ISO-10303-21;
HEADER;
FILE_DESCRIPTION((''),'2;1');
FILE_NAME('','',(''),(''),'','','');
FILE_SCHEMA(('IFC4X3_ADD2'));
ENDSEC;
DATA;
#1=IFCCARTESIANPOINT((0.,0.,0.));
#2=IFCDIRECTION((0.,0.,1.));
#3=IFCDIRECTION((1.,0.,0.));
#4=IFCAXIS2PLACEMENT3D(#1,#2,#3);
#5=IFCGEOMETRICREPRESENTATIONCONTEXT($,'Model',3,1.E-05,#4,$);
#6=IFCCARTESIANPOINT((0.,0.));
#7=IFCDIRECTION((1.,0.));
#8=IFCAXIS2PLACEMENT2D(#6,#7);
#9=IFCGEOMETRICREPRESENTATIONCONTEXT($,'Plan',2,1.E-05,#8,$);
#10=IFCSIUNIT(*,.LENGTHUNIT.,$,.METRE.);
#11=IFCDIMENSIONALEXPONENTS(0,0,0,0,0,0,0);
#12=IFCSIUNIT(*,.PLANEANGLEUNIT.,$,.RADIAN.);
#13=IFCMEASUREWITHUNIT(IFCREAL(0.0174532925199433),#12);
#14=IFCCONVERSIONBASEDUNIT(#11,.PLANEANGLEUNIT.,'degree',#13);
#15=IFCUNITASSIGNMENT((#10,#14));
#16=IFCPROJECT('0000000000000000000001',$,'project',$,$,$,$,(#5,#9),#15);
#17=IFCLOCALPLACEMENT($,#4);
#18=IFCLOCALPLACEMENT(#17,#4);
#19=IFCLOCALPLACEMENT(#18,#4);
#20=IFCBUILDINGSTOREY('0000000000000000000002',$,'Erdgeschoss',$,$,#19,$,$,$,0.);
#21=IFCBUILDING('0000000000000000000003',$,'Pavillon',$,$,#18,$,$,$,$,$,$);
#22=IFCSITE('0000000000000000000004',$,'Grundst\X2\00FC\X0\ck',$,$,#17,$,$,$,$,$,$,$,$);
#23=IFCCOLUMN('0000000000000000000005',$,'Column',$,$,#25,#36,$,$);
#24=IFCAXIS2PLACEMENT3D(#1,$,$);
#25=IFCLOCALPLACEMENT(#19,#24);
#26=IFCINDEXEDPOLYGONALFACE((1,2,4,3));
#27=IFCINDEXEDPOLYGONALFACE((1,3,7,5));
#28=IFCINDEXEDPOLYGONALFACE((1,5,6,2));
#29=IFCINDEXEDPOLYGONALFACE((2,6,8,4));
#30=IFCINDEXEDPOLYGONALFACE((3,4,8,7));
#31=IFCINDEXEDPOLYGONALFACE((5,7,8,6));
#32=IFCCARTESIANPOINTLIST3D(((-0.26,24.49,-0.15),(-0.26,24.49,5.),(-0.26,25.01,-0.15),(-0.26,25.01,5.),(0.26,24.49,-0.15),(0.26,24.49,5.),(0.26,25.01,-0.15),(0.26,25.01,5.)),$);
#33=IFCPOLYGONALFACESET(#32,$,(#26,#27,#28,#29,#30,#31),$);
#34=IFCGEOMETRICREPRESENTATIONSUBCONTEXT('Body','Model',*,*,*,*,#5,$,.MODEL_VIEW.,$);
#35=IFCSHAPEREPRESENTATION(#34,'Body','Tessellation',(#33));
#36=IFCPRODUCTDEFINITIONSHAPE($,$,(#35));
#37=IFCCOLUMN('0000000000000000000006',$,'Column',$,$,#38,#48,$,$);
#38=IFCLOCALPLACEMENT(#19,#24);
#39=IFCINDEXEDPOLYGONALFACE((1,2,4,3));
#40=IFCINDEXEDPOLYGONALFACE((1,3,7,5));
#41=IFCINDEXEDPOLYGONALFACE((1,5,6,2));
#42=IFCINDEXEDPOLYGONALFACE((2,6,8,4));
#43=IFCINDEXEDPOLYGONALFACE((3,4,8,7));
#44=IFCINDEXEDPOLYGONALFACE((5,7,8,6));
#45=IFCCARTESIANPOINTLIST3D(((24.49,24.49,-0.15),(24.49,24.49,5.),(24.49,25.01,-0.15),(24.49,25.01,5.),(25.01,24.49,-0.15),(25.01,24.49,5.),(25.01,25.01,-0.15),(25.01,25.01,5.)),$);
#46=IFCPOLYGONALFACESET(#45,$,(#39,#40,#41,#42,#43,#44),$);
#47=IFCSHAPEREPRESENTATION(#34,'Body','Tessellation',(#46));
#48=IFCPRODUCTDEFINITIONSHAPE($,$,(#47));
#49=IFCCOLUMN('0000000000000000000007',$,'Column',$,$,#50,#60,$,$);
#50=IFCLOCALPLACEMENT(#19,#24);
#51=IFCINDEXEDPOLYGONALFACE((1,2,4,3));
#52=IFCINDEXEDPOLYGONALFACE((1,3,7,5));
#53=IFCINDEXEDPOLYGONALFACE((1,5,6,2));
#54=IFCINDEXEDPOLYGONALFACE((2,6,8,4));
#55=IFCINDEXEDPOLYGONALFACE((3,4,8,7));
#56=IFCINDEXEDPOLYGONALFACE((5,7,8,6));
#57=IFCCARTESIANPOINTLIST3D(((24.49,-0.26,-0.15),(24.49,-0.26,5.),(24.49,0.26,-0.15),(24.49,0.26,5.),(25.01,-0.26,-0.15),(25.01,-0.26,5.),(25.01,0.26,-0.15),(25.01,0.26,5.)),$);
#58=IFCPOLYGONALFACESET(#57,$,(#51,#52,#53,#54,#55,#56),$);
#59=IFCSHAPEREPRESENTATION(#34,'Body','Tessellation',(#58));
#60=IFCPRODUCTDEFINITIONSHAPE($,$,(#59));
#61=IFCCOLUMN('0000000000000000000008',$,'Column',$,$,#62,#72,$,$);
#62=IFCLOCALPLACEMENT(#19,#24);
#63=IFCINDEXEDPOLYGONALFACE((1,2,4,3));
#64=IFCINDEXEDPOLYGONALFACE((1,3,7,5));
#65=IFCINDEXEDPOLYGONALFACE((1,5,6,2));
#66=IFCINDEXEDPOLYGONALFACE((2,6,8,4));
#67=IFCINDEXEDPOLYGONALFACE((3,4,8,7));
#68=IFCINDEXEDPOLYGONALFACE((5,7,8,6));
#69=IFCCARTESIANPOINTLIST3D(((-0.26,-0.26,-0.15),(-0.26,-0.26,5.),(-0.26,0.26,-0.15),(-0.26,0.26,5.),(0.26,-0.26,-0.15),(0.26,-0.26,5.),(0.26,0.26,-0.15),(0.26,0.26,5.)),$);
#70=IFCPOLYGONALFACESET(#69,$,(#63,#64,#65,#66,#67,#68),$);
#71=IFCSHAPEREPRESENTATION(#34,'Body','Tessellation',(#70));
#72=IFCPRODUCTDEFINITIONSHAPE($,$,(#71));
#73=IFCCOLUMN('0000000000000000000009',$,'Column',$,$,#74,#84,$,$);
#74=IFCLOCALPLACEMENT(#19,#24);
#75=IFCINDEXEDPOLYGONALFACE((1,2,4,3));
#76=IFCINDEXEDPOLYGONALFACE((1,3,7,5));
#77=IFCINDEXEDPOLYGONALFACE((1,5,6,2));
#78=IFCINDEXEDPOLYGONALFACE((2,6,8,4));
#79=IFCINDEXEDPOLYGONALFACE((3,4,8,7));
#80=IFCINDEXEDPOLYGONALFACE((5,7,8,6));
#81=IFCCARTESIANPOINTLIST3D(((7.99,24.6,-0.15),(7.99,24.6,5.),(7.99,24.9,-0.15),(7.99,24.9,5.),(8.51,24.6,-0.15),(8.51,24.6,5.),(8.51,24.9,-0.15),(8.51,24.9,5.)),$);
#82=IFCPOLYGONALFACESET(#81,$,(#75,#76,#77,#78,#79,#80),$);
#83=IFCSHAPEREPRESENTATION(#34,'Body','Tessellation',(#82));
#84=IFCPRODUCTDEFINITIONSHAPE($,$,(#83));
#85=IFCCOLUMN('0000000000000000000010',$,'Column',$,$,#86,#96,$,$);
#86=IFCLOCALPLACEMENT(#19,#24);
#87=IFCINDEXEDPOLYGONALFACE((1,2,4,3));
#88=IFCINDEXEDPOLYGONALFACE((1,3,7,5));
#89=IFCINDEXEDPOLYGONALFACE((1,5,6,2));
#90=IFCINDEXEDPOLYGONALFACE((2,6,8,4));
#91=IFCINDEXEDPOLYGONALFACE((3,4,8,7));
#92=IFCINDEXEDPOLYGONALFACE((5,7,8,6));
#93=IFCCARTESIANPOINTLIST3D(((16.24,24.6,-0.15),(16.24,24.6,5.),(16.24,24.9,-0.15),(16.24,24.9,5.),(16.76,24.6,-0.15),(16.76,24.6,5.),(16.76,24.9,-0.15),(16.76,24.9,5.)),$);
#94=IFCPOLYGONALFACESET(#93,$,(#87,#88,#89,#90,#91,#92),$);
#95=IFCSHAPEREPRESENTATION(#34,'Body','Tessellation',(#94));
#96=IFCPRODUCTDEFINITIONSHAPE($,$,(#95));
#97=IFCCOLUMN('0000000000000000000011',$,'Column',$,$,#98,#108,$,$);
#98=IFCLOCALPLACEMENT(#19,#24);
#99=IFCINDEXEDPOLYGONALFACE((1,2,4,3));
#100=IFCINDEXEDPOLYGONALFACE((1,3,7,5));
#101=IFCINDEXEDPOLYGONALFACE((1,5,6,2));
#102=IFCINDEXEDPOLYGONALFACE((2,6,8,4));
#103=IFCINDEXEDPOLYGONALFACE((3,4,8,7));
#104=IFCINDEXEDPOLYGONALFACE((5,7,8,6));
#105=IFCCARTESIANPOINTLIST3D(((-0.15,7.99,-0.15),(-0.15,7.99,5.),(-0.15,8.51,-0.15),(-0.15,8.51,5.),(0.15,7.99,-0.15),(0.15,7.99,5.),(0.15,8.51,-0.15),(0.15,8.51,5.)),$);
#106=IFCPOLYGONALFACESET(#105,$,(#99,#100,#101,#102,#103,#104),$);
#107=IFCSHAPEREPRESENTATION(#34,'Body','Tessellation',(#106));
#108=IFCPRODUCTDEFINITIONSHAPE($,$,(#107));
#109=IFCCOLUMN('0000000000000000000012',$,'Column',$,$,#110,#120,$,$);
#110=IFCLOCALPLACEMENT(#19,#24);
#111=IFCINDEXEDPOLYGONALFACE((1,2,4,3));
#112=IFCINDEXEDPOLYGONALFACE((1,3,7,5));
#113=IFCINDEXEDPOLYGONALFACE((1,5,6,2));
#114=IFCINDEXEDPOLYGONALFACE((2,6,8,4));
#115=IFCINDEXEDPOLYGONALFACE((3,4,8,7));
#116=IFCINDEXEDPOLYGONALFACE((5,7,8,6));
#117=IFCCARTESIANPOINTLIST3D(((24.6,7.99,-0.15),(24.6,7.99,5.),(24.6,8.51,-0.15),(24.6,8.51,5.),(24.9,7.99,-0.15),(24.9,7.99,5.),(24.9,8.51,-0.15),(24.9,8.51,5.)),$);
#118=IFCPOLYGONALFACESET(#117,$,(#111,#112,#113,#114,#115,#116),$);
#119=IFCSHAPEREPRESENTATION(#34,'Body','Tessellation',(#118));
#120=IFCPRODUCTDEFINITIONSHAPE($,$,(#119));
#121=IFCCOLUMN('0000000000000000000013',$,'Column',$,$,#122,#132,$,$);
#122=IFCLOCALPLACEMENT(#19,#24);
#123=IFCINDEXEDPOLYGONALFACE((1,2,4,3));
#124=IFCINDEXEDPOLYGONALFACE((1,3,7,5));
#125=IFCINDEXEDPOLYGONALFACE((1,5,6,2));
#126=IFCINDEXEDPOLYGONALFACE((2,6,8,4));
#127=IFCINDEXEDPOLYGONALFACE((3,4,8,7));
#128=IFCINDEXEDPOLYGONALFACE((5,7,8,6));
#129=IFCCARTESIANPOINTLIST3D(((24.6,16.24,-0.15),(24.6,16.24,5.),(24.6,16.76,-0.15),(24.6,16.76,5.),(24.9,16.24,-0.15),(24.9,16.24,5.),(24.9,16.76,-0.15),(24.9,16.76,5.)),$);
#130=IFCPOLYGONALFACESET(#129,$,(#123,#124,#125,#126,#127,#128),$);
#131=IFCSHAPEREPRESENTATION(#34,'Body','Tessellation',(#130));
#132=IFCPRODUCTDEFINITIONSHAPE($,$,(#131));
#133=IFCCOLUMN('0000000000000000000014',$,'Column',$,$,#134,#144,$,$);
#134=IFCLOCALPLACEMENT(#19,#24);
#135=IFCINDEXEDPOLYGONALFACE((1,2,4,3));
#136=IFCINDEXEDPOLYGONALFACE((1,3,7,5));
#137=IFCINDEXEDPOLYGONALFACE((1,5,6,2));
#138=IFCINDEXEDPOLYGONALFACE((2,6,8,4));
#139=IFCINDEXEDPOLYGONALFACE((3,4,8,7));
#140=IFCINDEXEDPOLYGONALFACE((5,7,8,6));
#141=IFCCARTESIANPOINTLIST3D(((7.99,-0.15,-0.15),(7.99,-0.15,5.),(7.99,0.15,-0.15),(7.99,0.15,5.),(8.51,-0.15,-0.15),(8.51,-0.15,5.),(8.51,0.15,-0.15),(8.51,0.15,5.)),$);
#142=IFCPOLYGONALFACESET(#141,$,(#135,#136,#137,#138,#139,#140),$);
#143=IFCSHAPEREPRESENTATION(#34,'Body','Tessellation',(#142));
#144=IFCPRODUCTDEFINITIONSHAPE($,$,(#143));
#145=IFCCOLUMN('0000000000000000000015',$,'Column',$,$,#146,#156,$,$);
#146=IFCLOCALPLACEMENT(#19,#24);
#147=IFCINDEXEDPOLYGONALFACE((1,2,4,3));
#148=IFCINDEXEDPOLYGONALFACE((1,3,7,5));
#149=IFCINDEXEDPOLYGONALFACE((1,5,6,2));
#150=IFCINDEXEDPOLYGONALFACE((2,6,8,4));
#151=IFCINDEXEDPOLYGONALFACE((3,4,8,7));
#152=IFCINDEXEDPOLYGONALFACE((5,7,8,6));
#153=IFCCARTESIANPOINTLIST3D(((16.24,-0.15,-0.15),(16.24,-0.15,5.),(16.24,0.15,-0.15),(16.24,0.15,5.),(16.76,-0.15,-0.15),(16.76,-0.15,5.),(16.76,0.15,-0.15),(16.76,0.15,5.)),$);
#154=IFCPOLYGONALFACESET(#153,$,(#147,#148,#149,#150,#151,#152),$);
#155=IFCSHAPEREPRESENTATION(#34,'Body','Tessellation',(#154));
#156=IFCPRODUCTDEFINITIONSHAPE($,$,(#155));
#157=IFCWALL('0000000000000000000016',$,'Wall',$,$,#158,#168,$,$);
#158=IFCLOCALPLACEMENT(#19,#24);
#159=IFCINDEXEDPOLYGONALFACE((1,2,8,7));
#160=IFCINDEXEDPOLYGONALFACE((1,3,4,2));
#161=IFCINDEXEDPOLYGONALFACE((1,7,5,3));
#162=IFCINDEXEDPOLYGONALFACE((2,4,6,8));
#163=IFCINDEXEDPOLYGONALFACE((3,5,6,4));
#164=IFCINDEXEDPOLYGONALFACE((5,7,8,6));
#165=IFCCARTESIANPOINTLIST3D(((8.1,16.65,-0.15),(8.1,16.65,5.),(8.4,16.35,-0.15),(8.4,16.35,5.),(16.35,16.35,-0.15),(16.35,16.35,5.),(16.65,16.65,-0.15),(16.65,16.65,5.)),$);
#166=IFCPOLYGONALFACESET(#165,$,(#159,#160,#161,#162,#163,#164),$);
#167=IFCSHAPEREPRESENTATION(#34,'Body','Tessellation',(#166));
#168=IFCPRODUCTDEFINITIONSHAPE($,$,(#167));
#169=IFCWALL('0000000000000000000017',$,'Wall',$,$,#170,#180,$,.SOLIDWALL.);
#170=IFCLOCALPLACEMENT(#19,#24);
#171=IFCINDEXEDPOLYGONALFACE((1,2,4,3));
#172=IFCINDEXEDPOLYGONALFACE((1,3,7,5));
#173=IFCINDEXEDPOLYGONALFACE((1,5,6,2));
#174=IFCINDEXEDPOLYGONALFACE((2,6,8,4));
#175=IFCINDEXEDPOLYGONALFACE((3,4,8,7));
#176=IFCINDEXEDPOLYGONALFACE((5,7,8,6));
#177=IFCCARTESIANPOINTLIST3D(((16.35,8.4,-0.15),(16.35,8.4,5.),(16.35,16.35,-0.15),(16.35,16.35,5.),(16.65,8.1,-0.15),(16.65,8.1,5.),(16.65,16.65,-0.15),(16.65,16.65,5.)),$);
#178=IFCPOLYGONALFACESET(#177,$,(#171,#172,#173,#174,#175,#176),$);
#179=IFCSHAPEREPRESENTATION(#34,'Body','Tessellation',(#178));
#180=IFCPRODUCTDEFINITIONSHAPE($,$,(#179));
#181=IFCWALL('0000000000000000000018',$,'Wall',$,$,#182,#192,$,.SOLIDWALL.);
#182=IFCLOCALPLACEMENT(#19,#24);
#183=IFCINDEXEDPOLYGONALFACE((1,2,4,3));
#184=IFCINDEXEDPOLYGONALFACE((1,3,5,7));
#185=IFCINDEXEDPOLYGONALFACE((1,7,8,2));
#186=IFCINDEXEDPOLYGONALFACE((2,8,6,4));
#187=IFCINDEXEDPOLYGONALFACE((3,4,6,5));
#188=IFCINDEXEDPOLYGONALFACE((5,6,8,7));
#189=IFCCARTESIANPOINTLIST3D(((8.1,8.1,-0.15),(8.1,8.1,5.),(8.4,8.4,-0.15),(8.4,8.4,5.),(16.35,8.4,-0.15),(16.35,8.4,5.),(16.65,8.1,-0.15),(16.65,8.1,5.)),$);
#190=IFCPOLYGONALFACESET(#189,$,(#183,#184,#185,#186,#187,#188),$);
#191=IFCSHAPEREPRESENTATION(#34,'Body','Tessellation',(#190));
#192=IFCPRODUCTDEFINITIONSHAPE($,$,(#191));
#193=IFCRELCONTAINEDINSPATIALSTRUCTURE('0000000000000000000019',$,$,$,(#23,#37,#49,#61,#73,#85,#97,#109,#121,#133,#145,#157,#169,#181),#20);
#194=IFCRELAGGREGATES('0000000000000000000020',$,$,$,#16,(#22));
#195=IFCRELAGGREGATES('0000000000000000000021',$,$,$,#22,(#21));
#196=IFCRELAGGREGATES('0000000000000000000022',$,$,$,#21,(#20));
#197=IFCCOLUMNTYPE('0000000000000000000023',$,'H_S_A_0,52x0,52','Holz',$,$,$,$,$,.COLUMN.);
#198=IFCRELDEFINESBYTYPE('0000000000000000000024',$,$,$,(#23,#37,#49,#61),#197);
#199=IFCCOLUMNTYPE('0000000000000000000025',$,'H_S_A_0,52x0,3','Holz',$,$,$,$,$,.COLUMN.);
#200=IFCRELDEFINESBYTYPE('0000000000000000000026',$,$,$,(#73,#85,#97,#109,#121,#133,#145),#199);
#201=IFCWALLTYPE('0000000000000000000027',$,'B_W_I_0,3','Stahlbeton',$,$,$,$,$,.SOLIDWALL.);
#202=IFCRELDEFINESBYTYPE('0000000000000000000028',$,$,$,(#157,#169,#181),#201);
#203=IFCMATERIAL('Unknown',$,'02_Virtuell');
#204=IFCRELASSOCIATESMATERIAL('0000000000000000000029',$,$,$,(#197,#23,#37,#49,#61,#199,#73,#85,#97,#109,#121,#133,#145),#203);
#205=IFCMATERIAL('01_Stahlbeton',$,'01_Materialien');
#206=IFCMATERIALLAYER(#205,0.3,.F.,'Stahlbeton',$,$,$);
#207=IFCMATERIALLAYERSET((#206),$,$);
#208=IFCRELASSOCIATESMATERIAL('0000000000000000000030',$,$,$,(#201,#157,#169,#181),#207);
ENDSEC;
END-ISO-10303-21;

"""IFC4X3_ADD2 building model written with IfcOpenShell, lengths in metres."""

from ifc_helpers import new_model, entity, si_unit, converted_unit, frame, origin_with_axes, origin_2d_with_axis, place, context, subcontext, project, spatial, line, indexed_curve, rectangle, outline, extrude, material, layer, layer_set, layer_usage, material_profile, profile_set, profile_usage, type_object, element, save


model = new_model("IFC4X3_ADD2")

# Units and contexts
model_context = context("Model", 3, precision=1e-05, world=origin_with_axes())
plan_context = context("Plan", 2, precision=1e-05, world=origin_2d_with_axis())
body_context = subcontext(model_context, "Body", "Model", "MODEL_VIEW")
ifc_project = project(units=[si_unit("LENGTHUNIT", "METRE"), converted_unit("PLANEANGLEUNIT", "degree", entity("IfcReal", 0.0174532925199433), si_unit("PLANEANGLEUNIT", "RADIAN"), dimensions=[0, 0, 0, 0, 0, 0, 0])], contexts=[model_context, plan_context])

# Site, building, storey
site_placement = place(None, origin_with_axes())
site = spatial("IfcSite", under=ifc_project, at=site_placement, Name="Grundstück")
building_placement = place(site_placement, origin_with_axes())
building = spatial("IfcBuilding", under=site, at=building_placement, Name="Pavillon")
storey_placement = place(building_placement, origin_with_axes())
storey = spatial("IfcBuildingStorey", under=building, at=storey_placement, Name="Erdgeschoss", Elevation=0.0)

# Columns
ifc_material_1 = material(Name="Unknown", Category="02_Virtuell")
ifc_material_profile_1 = material_profile(ifc_material_1, rectangle(XDim=0.52, YDim=0.52))
ifc_profile_set_1 = profile_set([ifc_material_profile_1])
ifc_profile_usage_1 = profile_usage(ifc_profile_set_1, cardinal=5)
column_type_1 = type_object("IfcColumnType", Name="H_S_A_0,52x0,52", Description="Holz", PredefinedType="COLUMN", material=ifc_profile_set_1)
column_1_placement = place(storey_placement, frame((0.0, 24.75, -0.15), z_axis=(0.0, 0.0, 1.0), x_axis=(1.0, 0.0, 0.0)))
element("IfcColumn", 1, at=column_1_placement, inside=storey, type_object=column_type_1, material=ifc_profile_usage_1, Name="Column", context=body_context, shape_type="SweptSolid", body=[
    extrude(rectangle(XDim=0.52, YDim=0.52), origin_with_axes(), (0.0, 0.0, 1.0), 5.15),
])
ifc_profile_usage_2 = profile_usage(ifc_profile_set_1, cardinal=5)
column_2_placement = place(storey_placement, frame((24.75, 24.75, -0.15), z_axis=(0.0, 0.0, 1.0), x_axis=(1.0, 0.0, 0.0)))
element("IfcColumn", 2, at=column_2_placement, inside=storey, type_object=column_type_1, material=ifc_profile_usage_2, Name="Column", context=body_context, shape_type="SweptSolid", body=[
    extrude(rectangle(XDim=0.52, YDim=0.52), origin_with_axes(), (0.0, 0.0, 1.0), 5.15),
])
ifc_profile_usage_3 = profile_usage(ifc_profile_set_1, cardinal=5)
column_3_placement = place(storey_placement, frame((24.75, 0.0, -0.15), z_axis=(0.0, 0.0, 1.0), x_axis=(1.0, 0.0, 0.0)))
element("IfcColumn", 3, at=column_3_placement, inside=storey, type_object=column_type_1, material=ifc_profile_usage_3, Name="Column", context=body_context, shape_type="SweptSolid", body=[
    extrude(rectangle(XDim=0.52, YDim=0.52), origin_with_axes(), (0.0, 0.0, 1.0), 5.15),
])
ifc_profile_usage_4 = profile_usage(ifc_profile_set_1, cardinal=5)
column_4_placement = place(storey_placement, frame((0.0, 0.0, -0.15), z_axis=(0.0, 0.0, 1.0), x_axis=(1.0, 0.0, 0.0)))
element("IfcColumn", 4, at=column_4_placement, inside=storey, type_object=column_type_1, material=ifc_profile_usage_4, Name="Column", context=body_context, shape_type="SweptSolid", body=[
    extrude(rectangle(XDim=0.52, YDim=0.52), origin_with_axes(), (0.0, 0.0, 1.0), 5.15),
])
ifc_material_profile_2 = material_profile(ifc_material_1, rectangle(XDim=0.52, YDim=0.3))
ifc_profile_set_2 = profile_set([ifc_material_profile_2])
ifc_profile_usage_5 = profile_usage(ifc_profile_set_2)
column_type_2 = type_object("IfcColumnType", Name="H_S_A_0,52x0,3", Description="Holz", PredefinedType="COLUMN", material=ifc_profile_set_2)
column_5_placement = place(storey_placement, frame((8.25, 24.75, -0.15), z_axis=(0.0, 0.0, 1.0), x_axis=(1.0, 0.0, 0.0)))
element("IfcColumn", 5, at=column_5_placement, inside=storey, type_object=column_type_2, material=ifc_profile_usage_5, Name="Column", context=body_context, shape_type="SweptSolid", body=[
    extrude(rectangle(XDim=0.52, YDim=0.3), origin_with_axes(), (0.0, 0.0, 1.0), 5.15),
])
ifc_profile_usage_6 = profile_usage(ifc_profile_set_2)
column_6_placement = place(storey_placement, frame((16.5, 24.75, -0.15), z_axis=(0.0, 0.0, 1.0), x_axis=(1.0, 0.0, 0.0)))
element("IfcColumn", 6, at=column_6_placement, inside=storey, type_object=column_type_2, material=ifc_profile_usage_6, Name="Column", context=body_context, shape_type="SweptSolid", body=[
    extrude(rectangle(XDim=0.52, YDim=0.3), origin_with_axes(), (0.0, 0.0, 1.0), 5.15),
])
ifc_profile_usage_7 = profile_usage(ifc_profile_set_2)
column_7_placement = place(storey_placement, frame((0.0, 8.25, -0.15), z_axis=(0.0, 0.0, 1.0), x_axis=(0.0, 1.0, 0.0)))
element("IfcColumn", 7, at=column_7_placement, inside=storey, type_object=column_type_2, material=ifc_profile_usage_7, Name="Column", context=body_context, shape_type="SweptSolid", body=[
    extrude(rectangle(XDim=0.52, YDim=0.3), origin_with_axes(), (0.0, 0.0, 1.0), 5.15),
])
ifc_profile_usage_8 = profile_usage(ifc_profile_set_2)
column_8_placement = place(storey_placement, frame((24.75, 8.25, -0.15), z_axis=(0.0, 0.0, 1.0), x_axis=(0.0, 1.0, 0.0)))
element("IfcColumn", 8, at=column_8_placement, inside=storey, type_object=column_type_2, material=ifc_profile_usage_8, Name="Column", context=body_context, shape_type="SweptSolid", body=[
    extrude(rectangle(XDim=0.52, YDim=0.3), origin_with_axes(), (0.0, 0.0, 1.0), 5.15),
])
ifc_profile_usage_9 = profile_usage(ifc_profile_set_2)
column_9_placement = place(storey_placement, frame((24.75, 16.5, -0.15), z_axis=(0.0, 0.0, 1.0), x_axis=(0.0, 1.0, 0.0)))
element("IfcColumn", 9, at=column_9_placement, inside=storey, type_object=column_type_2, material=ifc_profile_usage_9, Name="Column", context=body_context, shape_type="SweptSolid", body=[
    extrude(rectangle(XDim=0.52, YDim=0.3), origin_with_axes(), (0.0, 0.0, 1.0), 5.15),
])
ifc_profile_usage_10 = profile_usage(ifc_profile_set_2)
column_10_placement = place(storey_placement, frame((8.25, 0.0, -0.15), z_axis=(0.0, 0.0, 1.0), x_axis=(1.0, 0.0, 0.0)))
element("IfcColumn", 10, at=column_10_placement, inside=storey, type_object=column_type_2, material=ifc_profile_usage_10, Name="Column", context=body_context, shape_type="SweptSolid", body=[
    extrude(rectangle(XDim=0.52, YDim=0.3), origin_with_axes(), (0.0, 0.0, 1.0), 5.15),
])
ifc_profile_usage_11 = profile_usage(ifc_profile_set_2)
column_11_placement = place(storey_placement, frame((16.5, 0.0, -0.15), z_axis=(0.0, 0.0, 1.0), x_axis=(1.0, 0.0, 0.0)))
element("IfcColumn", 11, at=column_11_placement, inside=storey, type_object=column_type_2, material=ifc_profile_usage_11, Name="Column", context=body_context, shape_type="SweptSolid", body=[
    extrude(rectangle(XDim=0.52, YDim=0.3), origin_with_axes(), (0.0, 0.0, 1.0), 5.15),
])

# Walls
ifc_material_2 = material(Name="01_Stahlbeton", Category="01_Materialien")
ifc_layer = layer(ifc_material_2, 0.3, ventilated=False, Name="Stahlbeton")
ifc_layer_set = layer_set([ifc_layer])
ifc_layer_usage_1 = layer_usage(ifc_layer_set, "AXIS2", "POSITIVE", -0.15)
wall_type = type_object("IfcWallType", Name="B_W_I_0,3", Description="Stahlbeton", PredefinedType="SOLIDWALL", material=ifc_layer_set)
wall_1_placement = place(storey_placement, frame((8.25, 16.5, -0.15), z_axis=(0.0, 0.0, 1.0), x_axis=(1.0, 0.0, 0.0)))
element("IfcWall", 12, at=wall_1_placement, inside=storey, type_object=wall_type, material=ifc_layer_usage_1, Name="Wall", context=body_context, shape_type="SweptSolid", body=[
    extrude(outline(indexed_curve([(0.15, -0.15), (-0.15, 0.15), (8.4, 0.15), (8.1, -0.15)], segments=[line(1, 2, 3, 4, 1)])), origin_with_axes(), (0.0, 0.0, 1.0), 5.15),
])
ifc_layer_usage_2 = layer_usage(ifc_layer_set, "AXIS2", "POSITIVE", -0.15)
wall_2_placement = place(storey_placement, frame((16.5, 16.5, -0.15), z_axis=(0.0, 0.0, 1.0), x_axis=(0.0, -1.0, 0.0)))
element("IfcWall", 13, at=wall_2_placement, inside=storey, type_object=wall_type, material=ifc_layer_usage_2, Name="Wall", PredefinedType="SOLIDWALL", context=body_context, shape_type="SweptSolid", body=[
    extrude(outline(indexed_curve([(0.15, -0.15), (-0.15, 0.15), (8.4, 0.15), (8.1, -0.15)], segments=[line(1, 2, 3, 4, 1)])), origin_with_axes(), (0.0, 0.0, 1.0), 5.15),
])
ifc_layer_usage_3 = layer_usage(ifc_layer_set, "AXIS2", "POSITIVE", -0.15)
wall_3_placement = place(storey_placement, frame((8.25, 8.25, -0.15), z_axis=(0.0, 0.0, 1.0), x_axis=(1.0, 0.0, 0.0)))
element("IfcWall", 14, at=wall_3_placement, inside=storey, type_object=wall_type, material=ifc_layer_usage_3, Name="Wall", PredefinedType="SOLIDWALL", context=body_context, shape_type="SweptSolid", body=[
    extrude(outline(indexed_curve([(-0.15, -0.15), (0.15, 0.15), (8.1, 0.15), (8.4, -0.15)], segments=[line(1, 2, 3, 4, 1)])), origin_with_axes(), (0.0, 0.0, 1.0), 5.15),
])

save(model, "model.ifc")
